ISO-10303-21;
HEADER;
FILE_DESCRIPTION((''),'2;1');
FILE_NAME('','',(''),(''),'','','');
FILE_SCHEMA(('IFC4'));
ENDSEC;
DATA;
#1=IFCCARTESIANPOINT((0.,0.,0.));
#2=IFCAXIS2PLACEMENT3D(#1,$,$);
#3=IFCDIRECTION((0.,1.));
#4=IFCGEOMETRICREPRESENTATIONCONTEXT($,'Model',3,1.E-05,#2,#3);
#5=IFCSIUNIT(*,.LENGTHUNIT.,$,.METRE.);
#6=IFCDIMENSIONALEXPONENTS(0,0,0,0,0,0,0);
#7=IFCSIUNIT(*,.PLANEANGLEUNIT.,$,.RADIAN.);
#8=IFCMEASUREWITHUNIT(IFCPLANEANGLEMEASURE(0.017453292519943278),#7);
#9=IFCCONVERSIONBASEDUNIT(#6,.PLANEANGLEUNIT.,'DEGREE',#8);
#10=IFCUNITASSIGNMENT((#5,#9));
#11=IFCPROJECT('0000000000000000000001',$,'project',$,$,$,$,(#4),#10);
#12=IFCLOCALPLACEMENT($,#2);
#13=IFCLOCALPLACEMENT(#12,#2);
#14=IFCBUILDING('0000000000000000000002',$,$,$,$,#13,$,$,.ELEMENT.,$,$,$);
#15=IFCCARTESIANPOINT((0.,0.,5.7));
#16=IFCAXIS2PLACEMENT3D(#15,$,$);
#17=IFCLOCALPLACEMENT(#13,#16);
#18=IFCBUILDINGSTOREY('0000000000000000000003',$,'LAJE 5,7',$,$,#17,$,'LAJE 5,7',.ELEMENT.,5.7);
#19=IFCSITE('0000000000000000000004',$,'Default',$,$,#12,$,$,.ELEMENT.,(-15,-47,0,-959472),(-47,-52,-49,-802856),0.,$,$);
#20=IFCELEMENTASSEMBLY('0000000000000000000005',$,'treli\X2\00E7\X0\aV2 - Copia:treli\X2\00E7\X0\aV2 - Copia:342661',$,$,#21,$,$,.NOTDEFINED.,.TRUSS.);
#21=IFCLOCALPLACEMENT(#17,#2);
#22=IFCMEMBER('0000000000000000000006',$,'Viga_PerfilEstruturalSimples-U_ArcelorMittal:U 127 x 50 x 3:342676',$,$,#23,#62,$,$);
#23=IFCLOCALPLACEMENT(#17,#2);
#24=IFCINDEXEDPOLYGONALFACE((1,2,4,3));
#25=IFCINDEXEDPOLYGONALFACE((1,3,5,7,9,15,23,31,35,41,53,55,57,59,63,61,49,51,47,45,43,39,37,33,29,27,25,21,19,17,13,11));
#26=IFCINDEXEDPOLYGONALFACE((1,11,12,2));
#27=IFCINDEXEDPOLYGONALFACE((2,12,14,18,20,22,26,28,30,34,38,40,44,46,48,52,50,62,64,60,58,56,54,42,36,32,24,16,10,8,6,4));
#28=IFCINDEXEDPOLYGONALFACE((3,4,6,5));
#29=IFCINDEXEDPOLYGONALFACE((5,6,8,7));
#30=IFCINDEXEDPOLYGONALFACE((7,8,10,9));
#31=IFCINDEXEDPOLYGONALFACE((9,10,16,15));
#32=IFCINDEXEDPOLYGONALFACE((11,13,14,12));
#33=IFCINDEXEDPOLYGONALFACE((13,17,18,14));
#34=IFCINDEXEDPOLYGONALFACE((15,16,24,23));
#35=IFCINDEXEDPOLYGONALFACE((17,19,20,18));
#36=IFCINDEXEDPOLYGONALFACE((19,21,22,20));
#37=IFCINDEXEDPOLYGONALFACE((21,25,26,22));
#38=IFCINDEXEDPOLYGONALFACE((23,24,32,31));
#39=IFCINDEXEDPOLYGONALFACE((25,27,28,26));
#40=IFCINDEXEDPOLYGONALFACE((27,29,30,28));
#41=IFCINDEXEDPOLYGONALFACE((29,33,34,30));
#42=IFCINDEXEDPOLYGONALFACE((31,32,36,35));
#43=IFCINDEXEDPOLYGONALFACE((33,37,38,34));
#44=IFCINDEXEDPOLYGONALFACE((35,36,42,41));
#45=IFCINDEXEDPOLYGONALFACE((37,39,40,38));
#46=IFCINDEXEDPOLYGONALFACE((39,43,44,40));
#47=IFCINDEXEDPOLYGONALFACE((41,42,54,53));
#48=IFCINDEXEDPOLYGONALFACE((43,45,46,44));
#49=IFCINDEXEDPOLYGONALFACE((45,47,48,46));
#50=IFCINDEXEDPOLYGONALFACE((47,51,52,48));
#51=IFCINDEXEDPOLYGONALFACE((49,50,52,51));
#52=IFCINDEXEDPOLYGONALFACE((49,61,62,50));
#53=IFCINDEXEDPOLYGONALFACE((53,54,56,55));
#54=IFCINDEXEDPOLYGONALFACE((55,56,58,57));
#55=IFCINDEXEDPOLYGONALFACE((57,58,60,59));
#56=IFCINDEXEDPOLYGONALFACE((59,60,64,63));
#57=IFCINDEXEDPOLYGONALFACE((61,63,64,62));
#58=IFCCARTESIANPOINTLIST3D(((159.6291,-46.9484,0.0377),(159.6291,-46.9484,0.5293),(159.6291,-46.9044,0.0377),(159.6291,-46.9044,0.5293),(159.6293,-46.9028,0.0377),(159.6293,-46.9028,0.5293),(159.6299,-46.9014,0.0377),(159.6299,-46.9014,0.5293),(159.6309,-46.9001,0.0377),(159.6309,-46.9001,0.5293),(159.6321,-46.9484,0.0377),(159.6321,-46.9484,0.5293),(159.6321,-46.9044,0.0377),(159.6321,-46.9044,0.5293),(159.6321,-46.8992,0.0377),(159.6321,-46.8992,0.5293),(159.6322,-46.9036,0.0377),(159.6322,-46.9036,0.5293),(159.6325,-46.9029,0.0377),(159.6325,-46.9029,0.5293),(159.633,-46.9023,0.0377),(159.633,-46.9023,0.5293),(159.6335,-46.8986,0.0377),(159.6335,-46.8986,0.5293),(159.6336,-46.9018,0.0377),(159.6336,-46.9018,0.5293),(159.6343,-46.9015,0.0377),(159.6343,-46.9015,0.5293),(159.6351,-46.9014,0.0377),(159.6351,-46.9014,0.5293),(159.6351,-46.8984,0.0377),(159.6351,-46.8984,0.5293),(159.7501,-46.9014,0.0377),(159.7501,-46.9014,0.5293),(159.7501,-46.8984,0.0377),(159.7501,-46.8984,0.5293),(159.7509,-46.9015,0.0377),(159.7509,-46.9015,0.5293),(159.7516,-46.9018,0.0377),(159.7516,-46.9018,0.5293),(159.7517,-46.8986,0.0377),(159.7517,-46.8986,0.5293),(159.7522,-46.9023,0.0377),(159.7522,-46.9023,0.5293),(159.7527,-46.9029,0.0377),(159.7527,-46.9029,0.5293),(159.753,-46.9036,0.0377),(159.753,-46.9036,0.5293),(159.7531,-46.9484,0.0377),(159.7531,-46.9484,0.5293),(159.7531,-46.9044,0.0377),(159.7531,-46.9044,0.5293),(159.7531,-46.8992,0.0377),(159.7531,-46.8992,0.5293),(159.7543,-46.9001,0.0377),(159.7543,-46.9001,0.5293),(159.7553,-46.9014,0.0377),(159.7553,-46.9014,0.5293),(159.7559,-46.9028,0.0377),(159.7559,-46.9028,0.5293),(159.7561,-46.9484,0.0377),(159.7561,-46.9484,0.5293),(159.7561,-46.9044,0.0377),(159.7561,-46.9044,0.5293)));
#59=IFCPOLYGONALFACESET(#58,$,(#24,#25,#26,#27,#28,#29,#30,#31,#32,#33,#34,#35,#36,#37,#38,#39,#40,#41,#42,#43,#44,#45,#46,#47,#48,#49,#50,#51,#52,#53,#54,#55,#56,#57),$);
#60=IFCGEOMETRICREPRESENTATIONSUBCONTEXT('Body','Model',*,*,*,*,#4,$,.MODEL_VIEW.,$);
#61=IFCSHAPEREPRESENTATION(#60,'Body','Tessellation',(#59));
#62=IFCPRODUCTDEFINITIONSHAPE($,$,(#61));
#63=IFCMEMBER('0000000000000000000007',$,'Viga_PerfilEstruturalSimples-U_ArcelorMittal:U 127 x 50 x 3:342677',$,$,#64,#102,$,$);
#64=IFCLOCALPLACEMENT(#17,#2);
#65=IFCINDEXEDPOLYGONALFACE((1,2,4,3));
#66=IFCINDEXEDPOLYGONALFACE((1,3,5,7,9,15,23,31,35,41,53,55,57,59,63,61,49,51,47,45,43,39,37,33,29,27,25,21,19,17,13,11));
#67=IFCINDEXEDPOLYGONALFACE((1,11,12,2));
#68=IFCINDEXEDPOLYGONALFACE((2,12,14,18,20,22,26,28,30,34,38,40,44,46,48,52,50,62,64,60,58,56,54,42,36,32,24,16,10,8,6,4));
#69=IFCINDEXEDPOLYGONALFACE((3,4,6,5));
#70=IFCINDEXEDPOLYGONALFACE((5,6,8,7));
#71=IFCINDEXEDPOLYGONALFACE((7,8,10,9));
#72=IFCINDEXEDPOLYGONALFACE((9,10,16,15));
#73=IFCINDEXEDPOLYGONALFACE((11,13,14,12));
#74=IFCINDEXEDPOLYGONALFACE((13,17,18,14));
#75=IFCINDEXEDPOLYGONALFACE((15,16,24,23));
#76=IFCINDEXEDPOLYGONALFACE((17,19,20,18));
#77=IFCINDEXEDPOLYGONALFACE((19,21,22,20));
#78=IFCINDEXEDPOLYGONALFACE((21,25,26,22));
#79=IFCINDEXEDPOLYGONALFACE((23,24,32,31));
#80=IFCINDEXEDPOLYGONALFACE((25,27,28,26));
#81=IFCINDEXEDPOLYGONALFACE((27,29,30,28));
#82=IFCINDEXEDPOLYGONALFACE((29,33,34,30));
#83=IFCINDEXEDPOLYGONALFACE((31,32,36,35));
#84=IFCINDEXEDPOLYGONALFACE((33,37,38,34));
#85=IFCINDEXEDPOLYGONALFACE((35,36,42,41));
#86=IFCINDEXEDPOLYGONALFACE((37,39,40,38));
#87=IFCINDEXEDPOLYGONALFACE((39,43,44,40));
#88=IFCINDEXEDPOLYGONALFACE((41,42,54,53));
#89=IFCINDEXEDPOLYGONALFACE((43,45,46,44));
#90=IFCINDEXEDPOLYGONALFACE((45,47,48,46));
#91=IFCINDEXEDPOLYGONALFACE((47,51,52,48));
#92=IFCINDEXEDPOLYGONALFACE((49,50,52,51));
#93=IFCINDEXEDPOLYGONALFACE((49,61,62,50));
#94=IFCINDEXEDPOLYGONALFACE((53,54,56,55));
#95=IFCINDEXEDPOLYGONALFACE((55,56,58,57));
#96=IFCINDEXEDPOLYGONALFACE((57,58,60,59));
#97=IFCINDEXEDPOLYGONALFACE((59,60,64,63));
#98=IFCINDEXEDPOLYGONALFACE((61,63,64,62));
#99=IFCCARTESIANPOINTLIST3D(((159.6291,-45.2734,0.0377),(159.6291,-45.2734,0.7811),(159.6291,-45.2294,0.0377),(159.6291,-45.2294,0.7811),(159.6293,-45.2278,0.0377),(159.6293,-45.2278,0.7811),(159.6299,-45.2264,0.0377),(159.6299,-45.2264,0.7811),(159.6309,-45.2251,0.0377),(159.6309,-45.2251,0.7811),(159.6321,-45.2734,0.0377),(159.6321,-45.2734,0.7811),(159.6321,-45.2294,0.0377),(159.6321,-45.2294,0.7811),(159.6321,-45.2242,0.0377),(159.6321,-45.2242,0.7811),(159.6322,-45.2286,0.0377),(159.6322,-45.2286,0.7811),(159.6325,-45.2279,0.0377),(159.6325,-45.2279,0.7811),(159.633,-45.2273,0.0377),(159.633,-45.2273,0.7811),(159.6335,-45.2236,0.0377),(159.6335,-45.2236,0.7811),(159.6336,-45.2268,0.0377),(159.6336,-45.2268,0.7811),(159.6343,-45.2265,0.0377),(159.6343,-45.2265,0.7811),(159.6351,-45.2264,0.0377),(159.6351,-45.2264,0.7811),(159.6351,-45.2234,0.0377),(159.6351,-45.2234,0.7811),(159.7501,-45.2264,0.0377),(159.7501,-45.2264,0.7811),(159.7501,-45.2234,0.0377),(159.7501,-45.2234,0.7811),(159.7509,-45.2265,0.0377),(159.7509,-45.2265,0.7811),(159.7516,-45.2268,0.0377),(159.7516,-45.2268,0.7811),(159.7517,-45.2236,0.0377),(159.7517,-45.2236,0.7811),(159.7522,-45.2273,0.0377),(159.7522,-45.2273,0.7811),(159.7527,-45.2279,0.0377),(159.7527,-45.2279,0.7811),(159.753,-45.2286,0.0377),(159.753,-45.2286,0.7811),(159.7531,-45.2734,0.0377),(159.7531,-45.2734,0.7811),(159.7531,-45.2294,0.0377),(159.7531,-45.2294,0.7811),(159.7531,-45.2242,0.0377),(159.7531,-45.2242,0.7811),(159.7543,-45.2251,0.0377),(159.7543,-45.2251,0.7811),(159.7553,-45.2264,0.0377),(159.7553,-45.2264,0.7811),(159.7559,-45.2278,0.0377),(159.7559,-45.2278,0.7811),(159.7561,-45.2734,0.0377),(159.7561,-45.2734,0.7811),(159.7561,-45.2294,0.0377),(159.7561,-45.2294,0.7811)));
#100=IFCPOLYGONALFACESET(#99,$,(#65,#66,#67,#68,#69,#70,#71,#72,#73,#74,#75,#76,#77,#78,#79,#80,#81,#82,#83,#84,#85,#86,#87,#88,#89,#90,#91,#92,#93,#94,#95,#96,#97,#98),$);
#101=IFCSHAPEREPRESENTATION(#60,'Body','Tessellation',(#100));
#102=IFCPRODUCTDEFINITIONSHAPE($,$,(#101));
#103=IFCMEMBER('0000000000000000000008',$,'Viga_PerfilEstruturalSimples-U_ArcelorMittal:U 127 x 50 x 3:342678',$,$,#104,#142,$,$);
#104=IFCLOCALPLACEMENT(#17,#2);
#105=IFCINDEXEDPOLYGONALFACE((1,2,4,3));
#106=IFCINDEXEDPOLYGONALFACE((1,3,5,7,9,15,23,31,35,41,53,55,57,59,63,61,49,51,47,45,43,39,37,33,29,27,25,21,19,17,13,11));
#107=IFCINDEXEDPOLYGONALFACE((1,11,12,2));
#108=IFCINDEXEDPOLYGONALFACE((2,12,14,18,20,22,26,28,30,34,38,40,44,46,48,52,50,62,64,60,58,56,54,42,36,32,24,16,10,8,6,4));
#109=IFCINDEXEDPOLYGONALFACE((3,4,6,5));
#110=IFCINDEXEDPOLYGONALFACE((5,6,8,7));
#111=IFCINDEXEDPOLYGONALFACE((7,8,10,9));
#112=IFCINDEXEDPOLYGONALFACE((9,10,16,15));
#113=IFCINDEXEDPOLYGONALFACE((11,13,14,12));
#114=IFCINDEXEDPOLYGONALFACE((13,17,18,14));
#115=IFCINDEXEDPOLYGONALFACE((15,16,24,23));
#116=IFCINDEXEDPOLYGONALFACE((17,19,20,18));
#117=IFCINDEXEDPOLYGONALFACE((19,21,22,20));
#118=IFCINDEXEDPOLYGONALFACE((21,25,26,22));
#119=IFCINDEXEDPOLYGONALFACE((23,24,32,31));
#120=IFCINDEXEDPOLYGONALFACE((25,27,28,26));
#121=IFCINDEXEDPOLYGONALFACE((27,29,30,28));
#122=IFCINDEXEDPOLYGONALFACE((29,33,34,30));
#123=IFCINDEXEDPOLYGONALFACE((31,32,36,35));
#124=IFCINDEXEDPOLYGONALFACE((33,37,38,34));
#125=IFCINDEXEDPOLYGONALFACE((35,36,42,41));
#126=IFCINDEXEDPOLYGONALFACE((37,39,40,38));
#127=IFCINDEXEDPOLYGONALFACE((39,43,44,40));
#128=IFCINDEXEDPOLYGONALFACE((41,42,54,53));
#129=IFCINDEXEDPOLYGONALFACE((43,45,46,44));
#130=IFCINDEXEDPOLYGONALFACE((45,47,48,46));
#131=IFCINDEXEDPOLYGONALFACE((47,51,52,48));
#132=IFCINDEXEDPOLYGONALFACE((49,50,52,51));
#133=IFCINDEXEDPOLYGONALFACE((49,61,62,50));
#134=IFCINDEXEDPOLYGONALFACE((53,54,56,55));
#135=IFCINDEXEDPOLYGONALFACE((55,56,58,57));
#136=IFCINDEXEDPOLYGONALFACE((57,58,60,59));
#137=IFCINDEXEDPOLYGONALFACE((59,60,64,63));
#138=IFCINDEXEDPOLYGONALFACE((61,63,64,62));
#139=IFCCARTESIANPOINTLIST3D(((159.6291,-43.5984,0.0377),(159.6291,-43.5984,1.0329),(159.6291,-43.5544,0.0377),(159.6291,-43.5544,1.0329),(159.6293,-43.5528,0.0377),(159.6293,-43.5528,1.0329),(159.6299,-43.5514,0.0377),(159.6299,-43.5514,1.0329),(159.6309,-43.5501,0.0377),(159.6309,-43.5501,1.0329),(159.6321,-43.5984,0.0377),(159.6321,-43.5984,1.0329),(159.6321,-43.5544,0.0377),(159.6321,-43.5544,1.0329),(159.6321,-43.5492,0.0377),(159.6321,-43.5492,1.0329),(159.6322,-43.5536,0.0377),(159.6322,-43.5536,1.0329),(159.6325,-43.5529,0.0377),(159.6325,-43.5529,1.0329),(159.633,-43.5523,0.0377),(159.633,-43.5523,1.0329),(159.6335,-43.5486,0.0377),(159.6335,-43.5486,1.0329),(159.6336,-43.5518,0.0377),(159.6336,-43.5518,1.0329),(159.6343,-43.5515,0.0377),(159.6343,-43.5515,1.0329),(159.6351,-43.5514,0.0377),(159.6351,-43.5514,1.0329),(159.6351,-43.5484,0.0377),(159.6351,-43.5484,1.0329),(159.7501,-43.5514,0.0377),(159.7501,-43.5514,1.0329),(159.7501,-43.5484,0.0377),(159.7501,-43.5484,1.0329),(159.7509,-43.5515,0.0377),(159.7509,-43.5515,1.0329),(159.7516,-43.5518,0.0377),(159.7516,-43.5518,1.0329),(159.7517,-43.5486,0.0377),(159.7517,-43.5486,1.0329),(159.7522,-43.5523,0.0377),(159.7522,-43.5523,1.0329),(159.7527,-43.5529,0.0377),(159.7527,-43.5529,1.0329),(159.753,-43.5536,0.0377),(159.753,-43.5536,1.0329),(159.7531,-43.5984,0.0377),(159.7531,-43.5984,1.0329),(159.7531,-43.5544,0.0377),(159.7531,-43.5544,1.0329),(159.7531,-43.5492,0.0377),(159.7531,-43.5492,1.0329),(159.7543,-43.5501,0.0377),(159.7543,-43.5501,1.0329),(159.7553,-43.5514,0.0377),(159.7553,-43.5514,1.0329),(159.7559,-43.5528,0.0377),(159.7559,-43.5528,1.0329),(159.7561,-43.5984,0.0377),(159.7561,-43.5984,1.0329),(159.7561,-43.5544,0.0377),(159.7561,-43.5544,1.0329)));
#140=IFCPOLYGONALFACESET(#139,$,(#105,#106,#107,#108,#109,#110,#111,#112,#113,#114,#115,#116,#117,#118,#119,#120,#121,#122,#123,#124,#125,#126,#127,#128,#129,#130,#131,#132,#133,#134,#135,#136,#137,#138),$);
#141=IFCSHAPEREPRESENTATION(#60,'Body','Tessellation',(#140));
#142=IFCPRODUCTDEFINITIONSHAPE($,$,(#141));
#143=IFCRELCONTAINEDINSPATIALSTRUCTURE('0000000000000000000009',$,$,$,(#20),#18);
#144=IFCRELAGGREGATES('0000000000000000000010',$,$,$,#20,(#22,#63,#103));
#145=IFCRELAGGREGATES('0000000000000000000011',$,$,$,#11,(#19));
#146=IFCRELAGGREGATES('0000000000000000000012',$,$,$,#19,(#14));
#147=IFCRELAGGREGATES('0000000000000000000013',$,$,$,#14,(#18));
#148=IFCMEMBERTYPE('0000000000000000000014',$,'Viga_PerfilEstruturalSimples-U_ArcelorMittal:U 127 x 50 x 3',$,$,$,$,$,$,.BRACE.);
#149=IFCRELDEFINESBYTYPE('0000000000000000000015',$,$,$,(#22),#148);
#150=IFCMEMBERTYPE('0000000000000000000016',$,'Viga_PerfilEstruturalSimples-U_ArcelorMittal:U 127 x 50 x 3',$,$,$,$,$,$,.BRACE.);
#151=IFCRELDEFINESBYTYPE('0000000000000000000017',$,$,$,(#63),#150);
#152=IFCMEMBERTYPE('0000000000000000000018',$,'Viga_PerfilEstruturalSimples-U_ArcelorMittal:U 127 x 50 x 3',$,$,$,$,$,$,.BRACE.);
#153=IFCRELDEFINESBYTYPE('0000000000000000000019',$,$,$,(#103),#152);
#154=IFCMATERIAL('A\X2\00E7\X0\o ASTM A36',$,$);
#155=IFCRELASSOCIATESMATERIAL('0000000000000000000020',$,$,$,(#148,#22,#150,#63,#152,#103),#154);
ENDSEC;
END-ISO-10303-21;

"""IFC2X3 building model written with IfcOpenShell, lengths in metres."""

from ifc_helpers import new_model, entity, si_unit, converted_unit, direction, frame, frame_2d, origin, place, context, subcontext, project, spatial, polyline, circle_curve, parameter, trimmed, segment, composite_curve, outline, extrude, source, transform, mapped, material, type_object, type_shapes, element, aggregate, save


model = new_model("IFC2X3")

# Units and contexts
model_context = context("Model", 3, precision=1e-05, world=origin(), true_north=direction((0.0, 1.0)))
body_context = subcontext(model_context, "Body", "Model", "MODEL_VIEW")
ifc_project = project(units=[si_unit("LENGTHUNIT", "METRE"), converted_unit("PLANEANGLEUNIT", "DEGREE", entity("IfcPlaneAngleMeasure", 0.017453292519943278), si_unit("PLANEANGLEUNIT", "RADIAN"), dimensions=[0, 0, 0, 0, 0, 0, 0])], contexts=[model_context])

# Site, building, storey
site_placement = place(None, origin())
site = spatial("IfcSite", under=ifc_project, at=site_placement, Name="Default", CompositionType="ELEMENT", RefLatitude=(-15, -47, 0, -959472), RefLongitude=(-47, -52, -49, -802856), RefElevation=0.0)
building_placement = place(site_placement, origin())
building = spatial("IfcBuilding", under=site, at=building_placement, CompositionType="ELEMENT")
storey_placement = place(building_placement, frame((0.0, 0.0, 5.7)))
storey = spatial("IfcBuildingStorey", under=building, at=storey_placement, Name="LAJE 5,7", LongName="LAJE 5,7", CompositionType="ELEMENT", Elevation=5.7)

# Shared definitions
ifc_material = material(Name="Aço ASTM A36")

# Element assembly, member
assembly_1_placement = place(storey_placement, origin())
assembly_1 = element("IfcElementAssembly", 1, at=assembly_1_placement, inside=storey, Name="treliçaV2 - Copia:treliçaV2 - Copia:342661", AssemblyPlace="NOTDEFINED", PredefinedType="TRUSS")
member_type_1 = type_object("IfcMemberType", Name="Viga_PerfilEstruturalSimples-U_ArcelorMittal:U 127 x 50 x 3", PredefinedType="BRACE", material=ifc_material)
shared_shape_1 = source(origin(), body_context, "Body", "SweptSolid", [
    extrude(outline(composite_curve([segment(polyline([(-0.0575, -0.0192), (0.0575, -0.0192)]), True, "CONTINUOUS"), segment(trimmed(circle_curve(frame_2d((0.0575, -0.0132), x_axis=(0.0, 1.0)), 0.006), [parameter(180.0)], [parameter(270.0)], True, "PARAMETER"), True, "CONTINUOUS"), segment(polyline([(0.0635, -0.0132), (0.0635, 0.0308)]), True, "CONTINUOUS"), segment(polyline([(0.0635, 0.0308), (0.0605, 0.0308)]), True, "CONTINUOUS"), segment(polyline([(0.0605, 0.0308), (0.0605, -0.0132)]), True, "CONTINUOUS"), segment(trimmed(circle_curve(frame_2d((0.0575, -0.0132), x_axis=(0.0, 1.0)), 0.003), [parameter(180.0)], [parameter(270.0)], True, "PARAMETER"), False, "CONTINUOUS"), segment(polyline([(0.0575, -0.0162), (-0.0575, -0.0162)]), True, "CONTINUOUS"), segment(trimmed(circle_curve(frame_2d((-0.0575, -0.0132), x_axis=(0.0, 1.0)), 0.003), [parameter(90.0)], [parameter(180.0)], True, "PARAMETER"), False, "CONTINUOUS"), segment(polyline([(-0.0605, -0.0132), (-0.0605, 0.0308)]), True, "CONTINUOUS"), segment(polyline([(-0.0605, 0.0308), (-0.0635, 0.0308)]), True, "CONTINUOUS"), segment(polyline([(-0.0635, 0.0308), (-0.0635, -0.0132)]), True, "CONTINUOUS"), segment(trimmed(circle_curve(frame_2d((-0.0575, -0.0132), x_axis=(0.0, 1.0)), 0.006), [parameter(90.0)], [parameter(180.0)], True, "PARAMETER"), True, "CONTINUOUS")], self_intersect=False)), frame((-0.2478, -0.0058, 0.0), z_axis=(1.0, 0.0, 0.0), x_axis=(0.0, 0.0, -1.0)), (0.0, 0.0, 1.0), 0.4916),
])
type_shapes(member_type_1, [shared_shape_1])
member_1_placement = place(assembly_1_placement, frame((159.6926, -46.9234, 0.2855), z_axis=(1.0, 0.0, 0.0), x_axis=(0.0, 0.0, 1.0)))
member_1 = element("IfcMember", 2, at=member_1_placement, type_object=member_type_1, material=ifc_material, Name="Viga_PerfilEstruturalSimples-U_ArcelorMittal:U 127 x 50 x 3:342676", context=body_context, shape_type="MappedRepresentation", body=[
    mapped(shared_shape_1, transform((0.0, 0.0, 0.0), scale=1.0)),
])

# Members
member_type_2 = type_object("IfcMemberType", Name="Viga_PerfilEstruturalSimples-U_ArcelorMittal:U 127 x 50 x 3", PredefinedType="BRACE", material=ifc_material)
shared_shape_2 = source(origin(), body_context, "Body", "SweptSolid", [
    extrude(outline(composite_curve([segment(polyline([(-0.0575, -0.0192), (0.0575, -0.0192)]), True, "CONTINUOUS"), segment(trimmed(circle_curve(frame_2d((0.0575, -0.0132), x_axis=(0.0, 1.0)), 0.006), [parameter(180.0)], [parameter(270.0)], True, "PARAMETER"), True, "CONTINUOUS"), segment(polyline([(0.0635, -0.0132), (0.0635, 0.0308)]), True, "CONTINUOUS"), segment(polyline([(0.0635, 0.0308), (0.0605, 0.0308)]), True, "CONTINUOUS"), segment(polyline([(0.0605, 0.0308), (0.0605, -0.0132)]), True, "CONTINUOUS"), segment(trimmed(circle_curve(frame_2d((0.0575, -0.0132), x_axis=(0.0, 1.0)), 0.003), [parameter(180.0)], [parameter(270.0)], True, "PARAMETER"), False, "CONTINUOUS"), segment(polyline([(0.0575, -0.0162), (-0.0575, -0.0162)]), True, "CONTINUOUS"), segment(trimmed(circle_curve(frame_2d((-0.0575, -0.0132), x_axis=(0.0, 1.0)), 0.003), [parameter(90.0)], [parameter(180.0)], True, "PARAMETER"), False, "CONTINUOUS"), segment(polyline([(-0.0605, -0.0132), (-0.0605, 0.0308)]), True, "CONTINUOUS"), segment(polyline([(-0.0605, 0.0308), (-0.0635, 0.0308)]), True, "CONTINUOUS"), segment(polyline([(-0.0635, 0.0308), (-0.0635, -0.0132)]), True, "CONTINUOUS"), segment(trimmed(circle_curve(frame_2d((-0.0575, -0.0132), x_axis=(0.0, 1.0)), 0.006), [parameter(90.0)], [parameter(180.0)], True, "PARAMETER"), True, "CONTINUOUS")], self_intersect=False)), frame((-0.3737, -0.0058, 0.0), z_axis=(1.0, 0.0, 0.0), x_axis=(0.0, 0.0, -1.0)), (0.0, 0.0, 1.0), 0.7434),
])
type_shapes(member_type_2, [shared_shape_2])
member_2_placement = place(assembly_1_placement, frame((159.6926, -45.2484, 0.4114), z_axis=(1.0, 0.0, 0.0), x_axis=(0.0, 0.0, 1.0)))
member_2 = element("IfcMember", 3, at=member_2_placement, type_object=member_type_2, material=ifc_material, Name="Viga_PerfilEstruturalSimples-U_ArcelorMittal:U 127 x 50 x 3:342677", context=body_context, shape_type="MappedRepresentation", body=[
    mapped(shared_shape_2, transform((0.0, 0.0, 0.0), scale=1.0)),
])
member_type_3 = type_object("IfcMemberType", Name="Viga_PerfilEstruturalSimples-U_ArcelorMittal:U 127 x 50 x 3", PredefinedType="BRACE", material=ifc_material)
shared_shape_3 = source(origin(), body_context, "Body", "SweptSolid", [
    extrude(outline(composite_curve([segment(polyline([(-0.0575, -0.0192), (0.0575, -0.0192)]), True, "CONTINUOUS"), segment(trimmed(circle_curve(frame_2d((0.0575, -0.0132), x_axis=(0.0, 1.0)), 0.006), [parameter(180.0)], [parameter(270.0)], True, "PARAMETER"), True, "CONTINUOUS"), segment(polyline([(0.0635, -0.0132), (0.0635, 0.0308)]), True, "CONTINUOUS"), segment(polyline([(0.0635, 0.0308), (0.0605, 0.0308)]), True, "CONTINUOUS"), segment(polyline([(0.0605, 0.0308), (0.0605, -0.0132)]), True, "CONTINUOUS"), segment(trimmed(circle_curve(frame_2d((0.0575, -0.0132), x_axis=(0.0, 1.0)), 0.003), [parameter(180.0)], [parameter(270.0)], True, "PARAMETER"), False, "CONTINUOUS"), segment(polyline([(0.0575, -0.0162), (-0.0575, -0.0162)]), True, "CONTINUOUS"), segment(trimmed(circle_curve(frame_2d((-0.0575, -0.0132), x_axis=(0.0, 1.0)), 0.003), [parameter(90.0)], [parameter(180.0)], True, "PARAMETER"), False, "CONTINUOUS"), segment(polyline([(-0.0605, -0.0132), (-0.0605, 0.0308)]), True, "CONTINUOUS"), segment(polyline([(-0.0605, 0.0308), (-0.0635, 0.0308)]), True, "CONTINUOUS"), segment(polyline([(-0.0635, 0.0308), (-0.0635, -0.0132)]), True, "CONTINUOUS"), segment(trimmed(circle_curve(frame_2d((-0.0575, -0.0132), x_axis=(0.0, 1.0)), 0.006), [parameter(90.0)], [parameter(180.0)], True, "PARAMETER"), True, "CONTINUOUS")], self_intersect=False)), frame((-0.4996, -0.0058, 0.0), z_axis=(1.0, 0.0, 0.0), x_axis=(0.0, 0.0, -1.0)), (0.0, 0.0, 1.0), 0.9952),
])
type_shapes(member_type_3, [shared_shape_3])
member_3_placement = place(assembly_1_placement, frame((159.6926, -43.5734, 0.5373), z_axis=(1.0, 0.0, 0.0), x_axis=(0.0, 0.0, 1.0)))
member_3 = element("IfcMember", 4, at=member_3_placement, type_object=member_type_3, material=ifc_material, Name="Viga_PerfilEstruturalSimples-U_ArcelorMittal:U 127 x 50 x 3:342678", context=body_context, shape_type="MappedRepresentation", body=[
    mapped(shared_shape_3, transform((0.0, 0.0, 0.0), scale=1.0)),
])
aggregate(assembly_1, [member_1, member_2, member_3])

save(model, "model.ifc")
